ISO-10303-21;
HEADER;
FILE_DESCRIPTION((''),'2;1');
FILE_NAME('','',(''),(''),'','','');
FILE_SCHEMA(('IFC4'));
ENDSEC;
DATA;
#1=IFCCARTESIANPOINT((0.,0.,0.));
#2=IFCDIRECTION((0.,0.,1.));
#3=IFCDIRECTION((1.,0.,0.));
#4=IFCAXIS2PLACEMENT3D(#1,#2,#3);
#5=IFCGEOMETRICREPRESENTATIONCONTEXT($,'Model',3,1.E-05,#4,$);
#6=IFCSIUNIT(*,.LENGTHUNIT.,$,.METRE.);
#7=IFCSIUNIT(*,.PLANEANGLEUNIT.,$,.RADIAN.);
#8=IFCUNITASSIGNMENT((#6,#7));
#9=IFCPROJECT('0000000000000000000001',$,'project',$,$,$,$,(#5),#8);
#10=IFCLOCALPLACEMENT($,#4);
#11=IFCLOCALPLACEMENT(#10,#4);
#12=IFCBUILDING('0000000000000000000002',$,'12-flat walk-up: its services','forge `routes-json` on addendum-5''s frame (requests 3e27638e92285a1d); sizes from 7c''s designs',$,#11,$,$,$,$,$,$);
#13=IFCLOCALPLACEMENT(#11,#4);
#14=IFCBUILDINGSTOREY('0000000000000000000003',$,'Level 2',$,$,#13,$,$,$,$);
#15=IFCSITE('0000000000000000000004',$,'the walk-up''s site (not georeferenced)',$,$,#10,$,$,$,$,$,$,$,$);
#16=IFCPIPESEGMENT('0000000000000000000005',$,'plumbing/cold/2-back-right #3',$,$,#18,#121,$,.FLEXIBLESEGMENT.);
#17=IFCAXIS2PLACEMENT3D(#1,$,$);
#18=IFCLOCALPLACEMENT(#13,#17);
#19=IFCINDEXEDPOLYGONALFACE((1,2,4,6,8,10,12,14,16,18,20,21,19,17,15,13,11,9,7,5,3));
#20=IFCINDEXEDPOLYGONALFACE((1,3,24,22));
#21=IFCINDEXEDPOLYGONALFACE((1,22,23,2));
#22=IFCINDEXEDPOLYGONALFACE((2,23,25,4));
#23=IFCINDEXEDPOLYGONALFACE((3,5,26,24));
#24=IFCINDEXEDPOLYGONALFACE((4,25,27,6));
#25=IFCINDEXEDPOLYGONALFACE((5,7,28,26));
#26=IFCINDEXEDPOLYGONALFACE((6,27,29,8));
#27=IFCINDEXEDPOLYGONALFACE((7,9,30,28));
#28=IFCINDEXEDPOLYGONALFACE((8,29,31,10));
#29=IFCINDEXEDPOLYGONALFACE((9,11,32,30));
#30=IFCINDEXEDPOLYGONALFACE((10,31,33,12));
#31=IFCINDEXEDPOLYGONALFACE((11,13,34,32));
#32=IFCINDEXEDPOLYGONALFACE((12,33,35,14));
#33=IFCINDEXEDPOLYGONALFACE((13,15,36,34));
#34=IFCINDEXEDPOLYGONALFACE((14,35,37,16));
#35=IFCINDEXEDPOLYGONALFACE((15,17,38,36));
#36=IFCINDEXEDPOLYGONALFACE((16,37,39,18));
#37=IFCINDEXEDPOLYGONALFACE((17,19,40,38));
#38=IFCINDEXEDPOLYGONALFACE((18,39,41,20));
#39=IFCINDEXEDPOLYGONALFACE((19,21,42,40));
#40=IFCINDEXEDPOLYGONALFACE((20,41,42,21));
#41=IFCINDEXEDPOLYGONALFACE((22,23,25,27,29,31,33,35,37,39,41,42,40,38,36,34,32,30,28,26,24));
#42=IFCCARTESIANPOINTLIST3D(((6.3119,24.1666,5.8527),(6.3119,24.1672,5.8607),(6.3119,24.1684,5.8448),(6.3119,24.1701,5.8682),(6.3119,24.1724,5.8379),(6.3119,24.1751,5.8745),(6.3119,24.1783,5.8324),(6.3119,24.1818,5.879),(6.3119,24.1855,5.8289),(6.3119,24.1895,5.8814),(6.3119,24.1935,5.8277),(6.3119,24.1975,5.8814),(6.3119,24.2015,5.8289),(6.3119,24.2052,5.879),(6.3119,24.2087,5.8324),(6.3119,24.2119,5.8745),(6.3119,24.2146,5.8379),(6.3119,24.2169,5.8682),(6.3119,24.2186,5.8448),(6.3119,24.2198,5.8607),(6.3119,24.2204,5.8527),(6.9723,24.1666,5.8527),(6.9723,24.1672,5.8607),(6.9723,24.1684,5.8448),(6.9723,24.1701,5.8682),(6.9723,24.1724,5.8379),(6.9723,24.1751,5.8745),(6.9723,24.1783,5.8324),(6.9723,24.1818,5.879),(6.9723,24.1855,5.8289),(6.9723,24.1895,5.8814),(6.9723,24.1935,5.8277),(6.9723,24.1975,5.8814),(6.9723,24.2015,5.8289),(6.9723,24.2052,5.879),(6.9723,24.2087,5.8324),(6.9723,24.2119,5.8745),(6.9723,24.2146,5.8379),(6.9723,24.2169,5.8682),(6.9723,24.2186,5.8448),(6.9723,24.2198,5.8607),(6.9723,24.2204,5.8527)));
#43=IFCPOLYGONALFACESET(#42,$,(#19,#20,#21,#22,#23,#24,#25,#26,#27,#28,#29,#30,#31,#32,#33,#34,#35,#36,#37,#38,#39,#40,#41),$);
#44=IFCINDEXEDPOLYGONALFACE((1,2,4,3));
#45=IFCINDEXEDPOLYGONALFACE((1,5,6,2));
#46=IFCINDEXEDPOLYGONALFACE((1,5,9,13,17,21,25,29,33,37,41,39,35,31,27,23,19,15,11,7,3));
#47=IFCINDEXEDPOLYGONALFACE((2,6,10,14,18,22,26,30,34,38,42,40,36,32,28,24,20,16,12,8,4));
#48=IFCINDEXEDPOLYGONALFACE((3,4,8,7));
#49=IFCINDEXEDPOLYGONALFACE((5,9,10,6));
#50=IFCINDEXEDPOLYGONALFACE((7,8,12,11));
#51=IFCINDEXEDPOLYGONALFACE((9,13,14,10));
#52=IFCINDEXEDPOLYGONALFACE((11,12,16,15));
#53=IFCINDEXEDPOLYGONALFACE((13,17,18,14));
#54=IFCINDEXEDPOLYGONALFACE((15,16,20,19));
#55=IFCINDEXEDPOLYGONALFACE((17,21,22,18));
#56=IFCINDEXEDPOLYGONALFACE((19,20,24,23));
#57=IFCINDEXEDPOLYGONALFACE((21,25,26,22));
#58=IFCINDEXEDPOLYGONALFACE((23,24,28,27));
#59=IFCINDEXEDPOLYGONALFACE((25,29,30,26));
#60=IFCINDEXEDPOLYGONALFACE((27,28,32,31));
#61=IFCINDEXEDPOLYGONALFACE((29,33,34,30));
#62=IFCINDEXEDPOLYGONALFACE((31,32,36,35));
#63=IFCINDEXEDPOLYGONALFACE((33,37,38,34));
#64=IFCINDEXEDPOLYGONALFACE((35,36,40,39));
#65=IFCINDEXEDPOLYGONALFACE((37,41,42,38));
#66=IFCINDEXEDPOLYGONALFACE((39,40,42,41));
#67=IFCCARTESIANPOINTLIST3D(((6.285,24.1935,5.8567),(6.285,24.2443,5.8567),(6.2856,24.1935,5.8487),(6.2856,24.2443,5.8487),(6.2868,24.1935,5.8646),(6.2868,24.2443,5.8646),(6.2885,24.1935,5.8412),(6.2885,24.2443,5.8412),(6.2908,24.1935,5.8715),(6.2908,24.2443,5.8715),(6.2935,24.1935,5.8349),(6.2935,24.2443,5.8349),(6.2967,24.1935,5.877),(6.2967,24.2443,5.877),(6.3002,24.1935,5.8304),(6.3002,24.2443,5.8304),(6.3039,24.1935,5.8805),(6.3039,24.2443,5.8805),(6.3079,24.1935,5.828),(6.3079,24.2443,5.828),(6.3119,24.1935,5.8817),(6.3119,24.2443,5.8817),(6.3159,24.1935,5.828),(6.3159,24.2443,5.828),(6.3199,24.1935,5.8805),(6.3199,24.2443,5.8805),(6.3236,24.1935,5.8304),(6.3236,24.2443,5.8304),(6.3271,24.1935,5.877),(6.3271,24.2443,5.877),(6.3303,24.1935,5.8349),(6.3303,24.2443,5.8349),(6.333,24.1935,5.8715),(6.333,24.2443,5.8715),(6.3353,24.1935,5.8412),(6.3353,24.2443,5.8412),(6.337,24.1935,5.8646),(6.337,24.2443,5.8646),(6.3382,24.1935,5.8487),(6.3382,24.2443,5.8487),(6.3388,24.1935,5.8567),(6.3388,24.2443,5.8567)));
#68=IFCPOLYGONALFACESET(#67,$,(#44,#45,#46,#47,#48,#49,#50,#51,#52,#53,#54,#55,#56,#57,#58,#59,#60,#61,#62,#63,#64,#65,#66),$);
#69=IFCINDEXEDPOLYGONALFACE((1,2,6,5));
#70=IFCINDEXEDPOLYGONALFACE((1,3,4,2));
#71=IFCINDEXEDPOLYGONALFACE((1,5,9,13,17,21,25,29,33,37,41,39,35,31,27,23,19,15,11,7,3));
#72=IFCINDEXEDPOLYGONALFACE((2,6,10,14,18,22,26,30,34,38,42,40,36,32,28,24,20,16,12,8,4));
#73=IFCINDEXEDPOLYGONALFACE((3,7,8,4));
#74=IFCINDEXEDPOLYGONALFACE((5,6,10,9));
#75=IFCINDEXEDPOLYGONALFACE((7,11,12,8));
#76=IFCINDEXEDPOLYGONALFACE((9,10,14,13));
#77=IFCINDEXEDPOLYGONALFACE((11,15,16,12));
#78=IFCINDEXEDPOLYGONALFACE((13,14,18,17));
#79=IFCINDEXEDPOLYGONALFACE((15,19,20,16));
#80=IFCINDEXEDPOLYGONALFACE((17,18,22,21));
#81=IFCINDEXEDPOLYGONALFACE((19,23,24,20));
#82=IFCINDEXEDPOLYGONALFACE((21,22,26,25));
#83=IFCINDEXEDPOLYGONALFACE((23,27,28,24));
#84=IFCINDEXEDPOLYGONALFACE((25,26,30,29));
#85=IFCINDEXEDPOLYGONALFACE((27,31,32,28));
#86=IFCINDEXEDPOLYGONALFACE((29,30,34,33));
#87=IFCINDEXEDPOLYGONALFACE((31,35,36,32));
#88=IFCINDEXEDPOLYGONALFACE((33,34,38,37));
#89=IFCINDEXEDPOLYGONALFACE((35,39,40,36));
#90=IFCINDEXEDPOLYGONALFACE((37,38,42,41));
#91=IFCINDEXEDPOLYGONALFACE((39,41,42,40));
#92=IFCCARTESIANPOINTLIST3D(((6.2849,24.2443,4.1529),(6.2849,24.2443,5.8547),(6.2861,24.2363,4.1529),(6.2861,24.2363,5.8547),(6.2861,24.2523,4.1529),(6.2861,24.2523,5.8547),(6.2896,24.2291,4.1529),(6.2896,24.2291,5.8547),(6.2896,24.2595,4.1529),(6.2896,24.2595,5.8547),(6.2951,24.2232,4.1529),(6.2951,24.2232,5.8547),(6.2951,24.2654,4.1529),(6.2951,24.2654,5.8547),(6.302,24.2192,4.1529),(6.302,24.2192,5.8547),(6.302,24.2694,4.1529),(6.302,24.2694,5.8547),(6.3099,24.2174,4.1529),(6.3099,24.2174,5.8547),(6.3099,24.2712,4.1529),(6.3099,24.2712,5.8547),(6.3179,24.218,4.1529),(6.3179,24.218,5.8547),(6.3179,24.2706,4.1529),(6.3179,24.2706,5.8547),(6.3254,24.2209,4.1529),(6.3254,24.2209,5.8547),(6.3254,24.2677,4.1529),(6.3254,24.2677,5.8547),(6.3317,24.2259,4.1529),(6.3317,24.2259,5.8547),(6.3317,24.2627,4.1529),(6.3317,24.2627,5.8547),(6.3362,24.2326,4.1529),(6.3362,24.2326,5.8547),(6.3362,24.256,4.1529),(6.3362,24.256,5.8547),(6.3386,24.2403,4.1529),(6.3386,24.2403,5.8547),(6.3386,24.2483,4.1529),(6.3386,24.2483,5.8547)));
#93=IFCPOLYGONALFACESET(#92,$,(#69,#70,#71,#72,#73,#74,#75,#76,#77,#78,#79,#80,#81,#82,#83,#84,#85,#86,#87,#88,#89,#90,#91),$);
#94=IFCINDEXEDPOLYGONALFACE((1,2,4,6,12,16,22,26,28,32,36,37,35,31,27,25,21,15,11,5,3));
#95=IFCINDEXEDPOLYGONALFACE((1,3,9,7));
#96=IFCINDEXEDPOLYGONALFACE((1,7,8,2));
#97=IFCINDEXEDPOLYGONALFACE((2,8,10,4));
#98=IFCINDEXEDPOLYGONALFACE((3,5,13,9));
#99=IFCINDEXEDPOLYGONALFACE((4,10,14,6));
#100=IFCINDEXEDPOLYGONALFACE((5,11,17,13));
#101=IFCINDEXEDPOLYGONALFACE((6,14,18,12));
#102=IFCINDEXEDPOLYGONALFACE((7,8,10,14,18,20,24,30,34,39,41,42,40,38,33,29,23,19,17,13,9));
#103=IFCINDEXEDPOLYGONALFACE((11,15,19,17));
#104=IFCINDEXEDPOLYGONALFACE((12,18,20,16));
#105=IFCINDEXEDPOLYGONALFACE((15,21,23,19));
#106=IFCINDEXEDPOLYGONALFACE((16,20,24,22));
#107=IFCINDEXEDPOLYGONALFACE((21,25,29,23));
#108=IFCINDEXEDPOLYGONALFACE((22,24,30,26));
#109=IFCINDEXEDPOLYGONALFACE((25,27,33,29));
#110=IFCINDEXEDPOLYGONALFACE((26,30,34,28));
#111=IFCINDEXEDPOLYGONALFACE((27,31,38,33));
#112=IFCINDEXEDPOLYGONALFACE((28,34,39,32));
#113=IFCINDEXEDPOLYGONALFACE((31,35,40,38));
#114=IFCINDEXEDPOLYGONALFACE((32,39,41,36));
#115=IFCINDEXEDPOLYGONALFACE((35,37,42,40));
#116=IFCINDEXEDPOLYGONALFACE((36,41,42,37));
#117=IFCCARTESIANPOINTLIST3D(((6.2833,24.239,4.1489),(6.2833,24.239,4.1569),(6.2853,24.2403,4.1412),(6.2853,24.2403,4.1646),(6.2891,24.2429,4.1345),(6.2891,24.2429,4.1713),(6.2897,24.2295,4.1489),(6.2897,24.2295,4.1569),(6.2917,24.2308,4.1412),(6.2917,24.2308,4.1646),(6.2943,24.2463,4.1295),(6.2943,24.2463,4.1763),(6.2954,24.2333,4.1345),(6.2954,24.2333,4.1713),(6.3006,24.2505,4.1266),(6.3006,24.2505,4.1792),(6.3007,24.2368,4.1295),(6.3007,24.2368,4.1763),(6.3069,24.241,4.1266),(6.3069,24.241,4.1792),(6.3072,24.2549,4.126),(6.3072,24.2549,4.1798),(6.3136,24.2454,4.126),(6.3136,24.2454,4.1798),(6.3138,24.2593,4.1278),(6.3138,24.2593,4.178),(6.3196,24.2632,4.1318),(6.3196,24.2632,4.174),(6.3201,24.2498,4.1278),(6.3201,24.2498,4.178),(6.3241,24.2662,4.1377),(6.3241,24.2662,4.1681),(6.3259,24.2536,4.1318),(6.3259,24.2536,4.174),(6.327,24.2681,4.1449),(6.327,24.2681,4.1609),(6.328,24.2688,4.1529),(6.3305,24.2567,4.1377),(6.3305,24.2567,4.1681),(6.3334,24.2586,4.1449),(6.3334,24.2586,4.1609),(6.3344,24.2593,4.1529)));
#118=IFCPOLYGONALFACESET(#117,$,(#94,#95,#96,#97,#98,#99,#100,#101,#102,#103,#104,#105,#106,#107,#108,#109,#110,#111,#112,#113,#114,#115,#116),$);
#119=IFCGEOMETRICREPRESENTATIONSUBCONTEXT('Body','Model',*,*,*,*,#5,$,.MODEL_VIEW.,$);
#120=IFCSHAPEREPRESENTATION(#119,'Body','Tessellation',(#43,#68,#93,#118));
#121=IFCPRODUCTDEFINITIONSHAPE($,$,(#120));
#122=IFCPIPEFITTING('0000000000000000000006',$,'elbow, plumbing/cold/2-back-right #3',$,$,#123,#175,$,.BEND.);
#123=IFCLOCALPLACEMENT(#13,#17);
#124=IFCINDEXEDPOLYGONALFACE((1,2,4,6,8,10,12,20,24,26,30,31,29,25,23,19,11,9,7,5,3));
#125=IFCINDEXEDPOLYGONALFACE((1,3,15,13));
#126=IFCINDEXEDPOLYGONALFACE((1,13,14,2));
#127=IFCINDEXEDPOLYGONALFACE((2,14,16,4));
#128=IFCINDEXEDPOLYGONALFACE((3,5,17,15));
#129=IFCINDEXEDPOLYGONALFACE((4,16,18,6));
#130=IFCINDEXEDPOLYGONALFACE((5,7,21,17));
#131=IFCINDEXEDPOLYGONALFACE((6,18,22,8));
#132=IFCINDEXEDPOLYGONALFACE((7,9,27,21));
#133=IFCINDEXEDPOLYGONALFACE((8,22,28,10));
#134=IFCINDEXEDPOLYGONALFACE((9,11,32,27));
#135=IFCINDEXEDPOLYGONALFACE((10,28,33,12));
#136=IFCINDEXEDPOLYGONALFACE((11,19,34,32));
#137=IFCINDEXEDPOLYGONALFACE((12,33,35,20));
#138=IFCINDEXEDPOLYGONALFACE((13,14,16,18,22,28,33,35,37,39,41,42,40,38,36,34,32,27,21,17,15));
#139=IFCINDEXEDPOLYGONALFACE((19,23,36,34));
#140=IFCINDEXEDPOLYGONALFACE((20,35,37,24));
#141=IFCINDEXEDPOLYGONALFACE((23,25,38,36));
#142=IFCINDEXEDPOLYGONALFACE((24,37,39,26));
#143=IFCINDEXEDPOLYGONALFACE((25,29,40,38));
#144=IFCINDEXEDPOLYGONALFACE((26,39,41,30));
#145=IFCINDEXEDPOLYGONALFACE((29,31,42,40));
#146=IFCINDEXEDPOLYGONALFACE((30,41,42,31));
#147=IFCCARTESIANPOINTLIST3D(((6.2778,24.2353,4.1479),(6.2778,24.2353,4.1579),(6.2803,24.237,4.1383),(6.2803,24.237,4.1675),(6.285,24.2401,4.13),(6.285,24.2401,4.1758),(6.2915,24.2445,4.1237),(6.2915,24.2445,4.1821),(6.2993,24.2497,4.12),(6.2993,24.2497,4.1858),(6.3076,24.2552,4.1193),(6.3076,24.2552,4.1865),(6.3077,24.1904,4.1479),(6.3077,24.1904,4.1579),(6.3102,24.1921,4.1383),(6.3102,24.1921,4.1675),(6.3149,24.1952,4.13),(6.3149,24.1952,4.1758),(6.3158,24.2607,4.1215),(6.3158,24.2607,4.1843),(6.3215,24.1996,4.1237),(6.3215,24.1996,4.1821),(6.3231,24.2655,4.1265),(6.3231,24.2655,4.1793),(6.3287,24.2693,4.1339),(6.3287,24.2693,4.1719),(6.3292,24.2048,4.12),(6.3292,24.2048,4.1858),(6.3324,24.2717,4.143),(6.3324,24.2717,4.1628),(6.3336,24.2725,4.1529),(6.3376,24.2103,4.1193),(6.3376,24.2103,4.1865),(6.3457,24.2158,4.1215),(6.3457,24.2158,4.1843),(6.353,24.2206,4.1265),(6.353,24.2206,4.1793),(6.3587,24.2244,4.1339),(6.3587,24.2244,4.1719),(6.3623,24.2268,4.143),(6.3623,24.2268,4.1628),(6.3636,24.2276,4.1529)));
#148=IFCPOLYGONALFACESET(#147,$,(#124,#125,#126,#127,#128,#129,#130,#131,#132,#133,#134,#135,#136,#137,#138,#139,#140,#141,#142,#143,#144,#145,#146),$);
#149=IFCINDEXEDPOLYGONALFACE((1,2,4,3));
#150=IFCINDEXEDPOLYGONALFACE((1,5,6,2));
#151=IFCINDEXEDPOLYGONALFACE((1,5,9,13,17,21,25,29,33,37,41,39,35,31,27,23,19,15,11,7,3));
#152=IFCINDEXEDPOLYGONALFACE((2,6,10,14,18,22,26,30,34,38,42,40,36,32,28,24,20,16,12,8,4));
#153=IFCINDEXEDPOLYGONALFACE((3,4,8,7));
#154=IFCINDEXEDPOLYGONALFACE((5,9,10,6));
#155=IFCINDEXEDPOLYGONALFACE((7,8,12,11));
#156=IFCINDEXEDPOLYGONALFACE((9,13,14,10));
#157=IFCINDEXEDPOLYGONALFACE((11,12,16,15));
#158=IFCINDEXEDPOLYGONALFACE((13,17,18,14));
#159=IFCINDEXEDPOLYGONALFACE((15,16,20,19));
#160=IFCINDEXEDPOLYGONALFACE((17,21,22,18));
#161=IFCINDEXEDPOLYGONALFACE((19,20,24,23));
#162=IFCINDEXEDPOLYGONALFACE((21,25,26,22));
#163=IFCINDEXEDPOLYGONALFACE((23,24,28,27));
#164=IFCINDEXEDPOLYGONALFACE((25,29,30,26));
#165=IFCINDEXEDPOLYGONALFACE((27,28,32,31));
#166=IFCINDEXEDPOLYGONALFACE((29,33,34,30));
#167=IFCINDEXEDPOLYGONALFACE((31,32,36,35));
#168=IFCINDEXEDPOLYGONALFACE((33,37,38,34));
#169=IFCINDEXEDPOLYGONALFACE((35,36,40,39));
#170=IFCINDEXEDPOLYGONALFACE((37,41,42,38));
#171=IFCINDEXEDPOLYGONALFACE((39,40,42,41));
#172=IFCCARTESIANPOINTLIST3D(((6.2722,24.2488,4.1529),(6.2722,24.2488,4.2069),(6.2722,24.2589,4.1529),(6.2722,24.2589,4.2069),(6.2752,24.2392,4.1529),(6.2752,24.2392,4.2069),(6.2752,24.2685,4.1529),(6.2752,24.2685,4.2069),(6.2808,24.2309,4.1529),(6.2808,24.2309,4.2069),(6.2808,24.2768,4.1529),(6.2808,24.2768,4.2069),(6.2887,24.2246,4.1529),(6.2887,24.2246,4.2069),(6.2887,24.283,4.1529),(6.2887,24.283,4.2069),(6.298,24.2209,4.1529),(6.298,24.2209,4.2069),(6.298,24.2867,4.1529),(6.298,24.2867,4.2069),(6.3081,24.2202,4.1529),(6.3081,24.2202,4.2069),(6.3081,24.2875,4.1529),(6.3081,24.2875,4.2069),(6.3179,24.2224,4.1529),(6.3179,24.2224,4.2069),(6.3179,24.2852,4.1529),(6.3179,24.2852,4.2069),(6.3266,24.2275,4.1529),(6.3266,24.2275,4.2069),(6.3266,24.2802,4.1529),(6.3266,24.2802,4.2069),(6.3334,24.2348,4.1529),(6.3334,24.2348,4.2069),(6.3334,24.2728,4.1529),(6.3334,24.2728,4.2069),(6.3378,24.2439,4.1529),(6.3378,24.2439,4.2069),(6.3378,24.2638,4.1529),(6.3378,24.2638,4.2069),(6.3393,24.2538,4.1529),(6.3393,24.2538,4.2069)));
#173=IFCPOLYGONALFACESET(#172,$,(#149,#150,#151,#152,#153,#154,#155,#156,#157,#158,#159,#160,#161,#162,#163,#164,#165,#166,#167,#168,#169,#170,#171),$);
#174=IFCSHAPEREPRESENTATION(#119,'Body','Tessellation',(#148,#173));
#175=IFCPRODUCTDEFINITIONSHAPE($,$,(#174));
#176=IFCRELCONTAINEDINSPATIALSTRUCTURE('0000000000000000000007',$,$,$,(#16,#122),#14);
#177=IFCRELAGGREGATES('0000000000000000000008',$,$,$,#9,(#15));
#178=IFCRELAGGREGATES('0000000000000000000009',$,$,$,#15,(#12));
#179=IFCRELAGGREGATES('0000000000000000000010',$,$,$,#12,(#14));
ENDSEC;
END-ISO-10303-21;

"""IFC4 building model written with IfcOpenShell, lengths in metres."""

from ifc_helpers import new_model, entity, si_unit, frame, origin_with_axes, place, context, subcontext, project, spatial, element, save


model = new_model("IFC4")

# Units and contexts
model_context = context("Model", 3, precision=1e-05, world=origin_with_axes())
body_context = subcontext(model_context, "Body", "Model", "MODEL_VIEW")
ifc_project = project(units=[si_unit("LENGTHUNIT", "METRE"), si_unit("PLANEANGLEUNIT", "RADIAN")], contexts=[model_context])

# Site, building, storey
site_placement = place(None, origin_with_axes())
site = spatial("IfcSite", under=ifc_project, at=site_placement, Name="the walk-up's site (not georeferenced)")
building_placement = place(site_placement, origin_with_axes())
building = spatial("IfcBuilding", under=site, at=building_placement, Name="12-flat walk-up: its services", Description="forge `routes-json` on addendum-5's frame (requests 3e27638e92285a1d); sizes from 7c's designs")
storey_placement = place(building_placement, origin_with_axes())
storey = spatial("IfcBuildingStorey", under=building, at=storey_placement, Name="Level 2")

# Pipe segment
pipe_segment_1_placement = place(storey_placement, frame((6.9723, 24.1935, 5.8547), z_axis=(0.0, 0.0, 1.0), x_axis=(1.0, 0.0, 0.0)))
element("IfcPipeSegment", 1, at=pipe_segment_1_placement, inside=storey, Name="plumbing/cold/2-back-right #3", PredefinedType="FLEXIBLESEGMENT", context=body_context, shape_type="AdvancedSweptSolid", body=[
    entity("IfcSweptDiskSolid", entity("IfcPolyline", [entity("IfcCartesianPoint", [0.0, 0.0, 0.0]), entity("IfcCartesianPoint", [-0.6604, 0.0, 0.0])]), 0.027),
    entity("IfcSweptDiskSolid", entity("IfcPolyline", [entity("IfcCartesianPoint", [-0.6604, 0.0, 0.0]), entity("IfcCartesianPoint", [-0.6604, 0.0508, 0.0])]), 0.027),
    entity("IfcSweptDiskSolid", entity("IfcPolyline", [entity("IfcCartesianPoint", [-0.6604, 0.0508, 0.0]), entity("IfcCartesianPoint", [-0.6604, 0.0508, -1.7018])]), 0.027),
    entity("IfcSweptDiskSolid", entity("IfcPolyline", [entity("IfcCartesianPoint", [-0.6604, 0.0508, -1.7018]), entity("IfcCartesianPoint", [-0.6667, 0.0603, -1.7018])]), 0.027),
])

# Pipe fitting
pipe_fitting_1_placement = place(storey_placement, frame((6.3355, 24.2089, 4.1529), z_axis=(0.0, 0.0, 1.0), x_axis=(1.0, 0.0, 0.0)))
element("IfcPipeFitting", 2, at=pipe_fitting_1_placement, inside=storey, Name="elbow, plumbing/cold/2-back-right #3", PredefinedType="BEND", context=body_context, shape_type="AdvancedSweptSolid", body=[
    entity("IfcSweptDiskSolid", entity("IfcPolyline", [entity("IfcCartesianPoint", [0.0, 0.0, 0.0]), entity("IfcCartesianPoint", [-0.0299, 0.0449, 0.0])]), 0.0337),
    entity("IfcSweptDiskSolid", entity("IfcPolyline", [entity("IfcCartesianPoint", [-0.0299, 0.0449, 0.0]), entity("IfcCartesianPoint", [-0.0299, 0.0449, 0.054])]), 0.0337),
])

save(model, "model.ifc")
